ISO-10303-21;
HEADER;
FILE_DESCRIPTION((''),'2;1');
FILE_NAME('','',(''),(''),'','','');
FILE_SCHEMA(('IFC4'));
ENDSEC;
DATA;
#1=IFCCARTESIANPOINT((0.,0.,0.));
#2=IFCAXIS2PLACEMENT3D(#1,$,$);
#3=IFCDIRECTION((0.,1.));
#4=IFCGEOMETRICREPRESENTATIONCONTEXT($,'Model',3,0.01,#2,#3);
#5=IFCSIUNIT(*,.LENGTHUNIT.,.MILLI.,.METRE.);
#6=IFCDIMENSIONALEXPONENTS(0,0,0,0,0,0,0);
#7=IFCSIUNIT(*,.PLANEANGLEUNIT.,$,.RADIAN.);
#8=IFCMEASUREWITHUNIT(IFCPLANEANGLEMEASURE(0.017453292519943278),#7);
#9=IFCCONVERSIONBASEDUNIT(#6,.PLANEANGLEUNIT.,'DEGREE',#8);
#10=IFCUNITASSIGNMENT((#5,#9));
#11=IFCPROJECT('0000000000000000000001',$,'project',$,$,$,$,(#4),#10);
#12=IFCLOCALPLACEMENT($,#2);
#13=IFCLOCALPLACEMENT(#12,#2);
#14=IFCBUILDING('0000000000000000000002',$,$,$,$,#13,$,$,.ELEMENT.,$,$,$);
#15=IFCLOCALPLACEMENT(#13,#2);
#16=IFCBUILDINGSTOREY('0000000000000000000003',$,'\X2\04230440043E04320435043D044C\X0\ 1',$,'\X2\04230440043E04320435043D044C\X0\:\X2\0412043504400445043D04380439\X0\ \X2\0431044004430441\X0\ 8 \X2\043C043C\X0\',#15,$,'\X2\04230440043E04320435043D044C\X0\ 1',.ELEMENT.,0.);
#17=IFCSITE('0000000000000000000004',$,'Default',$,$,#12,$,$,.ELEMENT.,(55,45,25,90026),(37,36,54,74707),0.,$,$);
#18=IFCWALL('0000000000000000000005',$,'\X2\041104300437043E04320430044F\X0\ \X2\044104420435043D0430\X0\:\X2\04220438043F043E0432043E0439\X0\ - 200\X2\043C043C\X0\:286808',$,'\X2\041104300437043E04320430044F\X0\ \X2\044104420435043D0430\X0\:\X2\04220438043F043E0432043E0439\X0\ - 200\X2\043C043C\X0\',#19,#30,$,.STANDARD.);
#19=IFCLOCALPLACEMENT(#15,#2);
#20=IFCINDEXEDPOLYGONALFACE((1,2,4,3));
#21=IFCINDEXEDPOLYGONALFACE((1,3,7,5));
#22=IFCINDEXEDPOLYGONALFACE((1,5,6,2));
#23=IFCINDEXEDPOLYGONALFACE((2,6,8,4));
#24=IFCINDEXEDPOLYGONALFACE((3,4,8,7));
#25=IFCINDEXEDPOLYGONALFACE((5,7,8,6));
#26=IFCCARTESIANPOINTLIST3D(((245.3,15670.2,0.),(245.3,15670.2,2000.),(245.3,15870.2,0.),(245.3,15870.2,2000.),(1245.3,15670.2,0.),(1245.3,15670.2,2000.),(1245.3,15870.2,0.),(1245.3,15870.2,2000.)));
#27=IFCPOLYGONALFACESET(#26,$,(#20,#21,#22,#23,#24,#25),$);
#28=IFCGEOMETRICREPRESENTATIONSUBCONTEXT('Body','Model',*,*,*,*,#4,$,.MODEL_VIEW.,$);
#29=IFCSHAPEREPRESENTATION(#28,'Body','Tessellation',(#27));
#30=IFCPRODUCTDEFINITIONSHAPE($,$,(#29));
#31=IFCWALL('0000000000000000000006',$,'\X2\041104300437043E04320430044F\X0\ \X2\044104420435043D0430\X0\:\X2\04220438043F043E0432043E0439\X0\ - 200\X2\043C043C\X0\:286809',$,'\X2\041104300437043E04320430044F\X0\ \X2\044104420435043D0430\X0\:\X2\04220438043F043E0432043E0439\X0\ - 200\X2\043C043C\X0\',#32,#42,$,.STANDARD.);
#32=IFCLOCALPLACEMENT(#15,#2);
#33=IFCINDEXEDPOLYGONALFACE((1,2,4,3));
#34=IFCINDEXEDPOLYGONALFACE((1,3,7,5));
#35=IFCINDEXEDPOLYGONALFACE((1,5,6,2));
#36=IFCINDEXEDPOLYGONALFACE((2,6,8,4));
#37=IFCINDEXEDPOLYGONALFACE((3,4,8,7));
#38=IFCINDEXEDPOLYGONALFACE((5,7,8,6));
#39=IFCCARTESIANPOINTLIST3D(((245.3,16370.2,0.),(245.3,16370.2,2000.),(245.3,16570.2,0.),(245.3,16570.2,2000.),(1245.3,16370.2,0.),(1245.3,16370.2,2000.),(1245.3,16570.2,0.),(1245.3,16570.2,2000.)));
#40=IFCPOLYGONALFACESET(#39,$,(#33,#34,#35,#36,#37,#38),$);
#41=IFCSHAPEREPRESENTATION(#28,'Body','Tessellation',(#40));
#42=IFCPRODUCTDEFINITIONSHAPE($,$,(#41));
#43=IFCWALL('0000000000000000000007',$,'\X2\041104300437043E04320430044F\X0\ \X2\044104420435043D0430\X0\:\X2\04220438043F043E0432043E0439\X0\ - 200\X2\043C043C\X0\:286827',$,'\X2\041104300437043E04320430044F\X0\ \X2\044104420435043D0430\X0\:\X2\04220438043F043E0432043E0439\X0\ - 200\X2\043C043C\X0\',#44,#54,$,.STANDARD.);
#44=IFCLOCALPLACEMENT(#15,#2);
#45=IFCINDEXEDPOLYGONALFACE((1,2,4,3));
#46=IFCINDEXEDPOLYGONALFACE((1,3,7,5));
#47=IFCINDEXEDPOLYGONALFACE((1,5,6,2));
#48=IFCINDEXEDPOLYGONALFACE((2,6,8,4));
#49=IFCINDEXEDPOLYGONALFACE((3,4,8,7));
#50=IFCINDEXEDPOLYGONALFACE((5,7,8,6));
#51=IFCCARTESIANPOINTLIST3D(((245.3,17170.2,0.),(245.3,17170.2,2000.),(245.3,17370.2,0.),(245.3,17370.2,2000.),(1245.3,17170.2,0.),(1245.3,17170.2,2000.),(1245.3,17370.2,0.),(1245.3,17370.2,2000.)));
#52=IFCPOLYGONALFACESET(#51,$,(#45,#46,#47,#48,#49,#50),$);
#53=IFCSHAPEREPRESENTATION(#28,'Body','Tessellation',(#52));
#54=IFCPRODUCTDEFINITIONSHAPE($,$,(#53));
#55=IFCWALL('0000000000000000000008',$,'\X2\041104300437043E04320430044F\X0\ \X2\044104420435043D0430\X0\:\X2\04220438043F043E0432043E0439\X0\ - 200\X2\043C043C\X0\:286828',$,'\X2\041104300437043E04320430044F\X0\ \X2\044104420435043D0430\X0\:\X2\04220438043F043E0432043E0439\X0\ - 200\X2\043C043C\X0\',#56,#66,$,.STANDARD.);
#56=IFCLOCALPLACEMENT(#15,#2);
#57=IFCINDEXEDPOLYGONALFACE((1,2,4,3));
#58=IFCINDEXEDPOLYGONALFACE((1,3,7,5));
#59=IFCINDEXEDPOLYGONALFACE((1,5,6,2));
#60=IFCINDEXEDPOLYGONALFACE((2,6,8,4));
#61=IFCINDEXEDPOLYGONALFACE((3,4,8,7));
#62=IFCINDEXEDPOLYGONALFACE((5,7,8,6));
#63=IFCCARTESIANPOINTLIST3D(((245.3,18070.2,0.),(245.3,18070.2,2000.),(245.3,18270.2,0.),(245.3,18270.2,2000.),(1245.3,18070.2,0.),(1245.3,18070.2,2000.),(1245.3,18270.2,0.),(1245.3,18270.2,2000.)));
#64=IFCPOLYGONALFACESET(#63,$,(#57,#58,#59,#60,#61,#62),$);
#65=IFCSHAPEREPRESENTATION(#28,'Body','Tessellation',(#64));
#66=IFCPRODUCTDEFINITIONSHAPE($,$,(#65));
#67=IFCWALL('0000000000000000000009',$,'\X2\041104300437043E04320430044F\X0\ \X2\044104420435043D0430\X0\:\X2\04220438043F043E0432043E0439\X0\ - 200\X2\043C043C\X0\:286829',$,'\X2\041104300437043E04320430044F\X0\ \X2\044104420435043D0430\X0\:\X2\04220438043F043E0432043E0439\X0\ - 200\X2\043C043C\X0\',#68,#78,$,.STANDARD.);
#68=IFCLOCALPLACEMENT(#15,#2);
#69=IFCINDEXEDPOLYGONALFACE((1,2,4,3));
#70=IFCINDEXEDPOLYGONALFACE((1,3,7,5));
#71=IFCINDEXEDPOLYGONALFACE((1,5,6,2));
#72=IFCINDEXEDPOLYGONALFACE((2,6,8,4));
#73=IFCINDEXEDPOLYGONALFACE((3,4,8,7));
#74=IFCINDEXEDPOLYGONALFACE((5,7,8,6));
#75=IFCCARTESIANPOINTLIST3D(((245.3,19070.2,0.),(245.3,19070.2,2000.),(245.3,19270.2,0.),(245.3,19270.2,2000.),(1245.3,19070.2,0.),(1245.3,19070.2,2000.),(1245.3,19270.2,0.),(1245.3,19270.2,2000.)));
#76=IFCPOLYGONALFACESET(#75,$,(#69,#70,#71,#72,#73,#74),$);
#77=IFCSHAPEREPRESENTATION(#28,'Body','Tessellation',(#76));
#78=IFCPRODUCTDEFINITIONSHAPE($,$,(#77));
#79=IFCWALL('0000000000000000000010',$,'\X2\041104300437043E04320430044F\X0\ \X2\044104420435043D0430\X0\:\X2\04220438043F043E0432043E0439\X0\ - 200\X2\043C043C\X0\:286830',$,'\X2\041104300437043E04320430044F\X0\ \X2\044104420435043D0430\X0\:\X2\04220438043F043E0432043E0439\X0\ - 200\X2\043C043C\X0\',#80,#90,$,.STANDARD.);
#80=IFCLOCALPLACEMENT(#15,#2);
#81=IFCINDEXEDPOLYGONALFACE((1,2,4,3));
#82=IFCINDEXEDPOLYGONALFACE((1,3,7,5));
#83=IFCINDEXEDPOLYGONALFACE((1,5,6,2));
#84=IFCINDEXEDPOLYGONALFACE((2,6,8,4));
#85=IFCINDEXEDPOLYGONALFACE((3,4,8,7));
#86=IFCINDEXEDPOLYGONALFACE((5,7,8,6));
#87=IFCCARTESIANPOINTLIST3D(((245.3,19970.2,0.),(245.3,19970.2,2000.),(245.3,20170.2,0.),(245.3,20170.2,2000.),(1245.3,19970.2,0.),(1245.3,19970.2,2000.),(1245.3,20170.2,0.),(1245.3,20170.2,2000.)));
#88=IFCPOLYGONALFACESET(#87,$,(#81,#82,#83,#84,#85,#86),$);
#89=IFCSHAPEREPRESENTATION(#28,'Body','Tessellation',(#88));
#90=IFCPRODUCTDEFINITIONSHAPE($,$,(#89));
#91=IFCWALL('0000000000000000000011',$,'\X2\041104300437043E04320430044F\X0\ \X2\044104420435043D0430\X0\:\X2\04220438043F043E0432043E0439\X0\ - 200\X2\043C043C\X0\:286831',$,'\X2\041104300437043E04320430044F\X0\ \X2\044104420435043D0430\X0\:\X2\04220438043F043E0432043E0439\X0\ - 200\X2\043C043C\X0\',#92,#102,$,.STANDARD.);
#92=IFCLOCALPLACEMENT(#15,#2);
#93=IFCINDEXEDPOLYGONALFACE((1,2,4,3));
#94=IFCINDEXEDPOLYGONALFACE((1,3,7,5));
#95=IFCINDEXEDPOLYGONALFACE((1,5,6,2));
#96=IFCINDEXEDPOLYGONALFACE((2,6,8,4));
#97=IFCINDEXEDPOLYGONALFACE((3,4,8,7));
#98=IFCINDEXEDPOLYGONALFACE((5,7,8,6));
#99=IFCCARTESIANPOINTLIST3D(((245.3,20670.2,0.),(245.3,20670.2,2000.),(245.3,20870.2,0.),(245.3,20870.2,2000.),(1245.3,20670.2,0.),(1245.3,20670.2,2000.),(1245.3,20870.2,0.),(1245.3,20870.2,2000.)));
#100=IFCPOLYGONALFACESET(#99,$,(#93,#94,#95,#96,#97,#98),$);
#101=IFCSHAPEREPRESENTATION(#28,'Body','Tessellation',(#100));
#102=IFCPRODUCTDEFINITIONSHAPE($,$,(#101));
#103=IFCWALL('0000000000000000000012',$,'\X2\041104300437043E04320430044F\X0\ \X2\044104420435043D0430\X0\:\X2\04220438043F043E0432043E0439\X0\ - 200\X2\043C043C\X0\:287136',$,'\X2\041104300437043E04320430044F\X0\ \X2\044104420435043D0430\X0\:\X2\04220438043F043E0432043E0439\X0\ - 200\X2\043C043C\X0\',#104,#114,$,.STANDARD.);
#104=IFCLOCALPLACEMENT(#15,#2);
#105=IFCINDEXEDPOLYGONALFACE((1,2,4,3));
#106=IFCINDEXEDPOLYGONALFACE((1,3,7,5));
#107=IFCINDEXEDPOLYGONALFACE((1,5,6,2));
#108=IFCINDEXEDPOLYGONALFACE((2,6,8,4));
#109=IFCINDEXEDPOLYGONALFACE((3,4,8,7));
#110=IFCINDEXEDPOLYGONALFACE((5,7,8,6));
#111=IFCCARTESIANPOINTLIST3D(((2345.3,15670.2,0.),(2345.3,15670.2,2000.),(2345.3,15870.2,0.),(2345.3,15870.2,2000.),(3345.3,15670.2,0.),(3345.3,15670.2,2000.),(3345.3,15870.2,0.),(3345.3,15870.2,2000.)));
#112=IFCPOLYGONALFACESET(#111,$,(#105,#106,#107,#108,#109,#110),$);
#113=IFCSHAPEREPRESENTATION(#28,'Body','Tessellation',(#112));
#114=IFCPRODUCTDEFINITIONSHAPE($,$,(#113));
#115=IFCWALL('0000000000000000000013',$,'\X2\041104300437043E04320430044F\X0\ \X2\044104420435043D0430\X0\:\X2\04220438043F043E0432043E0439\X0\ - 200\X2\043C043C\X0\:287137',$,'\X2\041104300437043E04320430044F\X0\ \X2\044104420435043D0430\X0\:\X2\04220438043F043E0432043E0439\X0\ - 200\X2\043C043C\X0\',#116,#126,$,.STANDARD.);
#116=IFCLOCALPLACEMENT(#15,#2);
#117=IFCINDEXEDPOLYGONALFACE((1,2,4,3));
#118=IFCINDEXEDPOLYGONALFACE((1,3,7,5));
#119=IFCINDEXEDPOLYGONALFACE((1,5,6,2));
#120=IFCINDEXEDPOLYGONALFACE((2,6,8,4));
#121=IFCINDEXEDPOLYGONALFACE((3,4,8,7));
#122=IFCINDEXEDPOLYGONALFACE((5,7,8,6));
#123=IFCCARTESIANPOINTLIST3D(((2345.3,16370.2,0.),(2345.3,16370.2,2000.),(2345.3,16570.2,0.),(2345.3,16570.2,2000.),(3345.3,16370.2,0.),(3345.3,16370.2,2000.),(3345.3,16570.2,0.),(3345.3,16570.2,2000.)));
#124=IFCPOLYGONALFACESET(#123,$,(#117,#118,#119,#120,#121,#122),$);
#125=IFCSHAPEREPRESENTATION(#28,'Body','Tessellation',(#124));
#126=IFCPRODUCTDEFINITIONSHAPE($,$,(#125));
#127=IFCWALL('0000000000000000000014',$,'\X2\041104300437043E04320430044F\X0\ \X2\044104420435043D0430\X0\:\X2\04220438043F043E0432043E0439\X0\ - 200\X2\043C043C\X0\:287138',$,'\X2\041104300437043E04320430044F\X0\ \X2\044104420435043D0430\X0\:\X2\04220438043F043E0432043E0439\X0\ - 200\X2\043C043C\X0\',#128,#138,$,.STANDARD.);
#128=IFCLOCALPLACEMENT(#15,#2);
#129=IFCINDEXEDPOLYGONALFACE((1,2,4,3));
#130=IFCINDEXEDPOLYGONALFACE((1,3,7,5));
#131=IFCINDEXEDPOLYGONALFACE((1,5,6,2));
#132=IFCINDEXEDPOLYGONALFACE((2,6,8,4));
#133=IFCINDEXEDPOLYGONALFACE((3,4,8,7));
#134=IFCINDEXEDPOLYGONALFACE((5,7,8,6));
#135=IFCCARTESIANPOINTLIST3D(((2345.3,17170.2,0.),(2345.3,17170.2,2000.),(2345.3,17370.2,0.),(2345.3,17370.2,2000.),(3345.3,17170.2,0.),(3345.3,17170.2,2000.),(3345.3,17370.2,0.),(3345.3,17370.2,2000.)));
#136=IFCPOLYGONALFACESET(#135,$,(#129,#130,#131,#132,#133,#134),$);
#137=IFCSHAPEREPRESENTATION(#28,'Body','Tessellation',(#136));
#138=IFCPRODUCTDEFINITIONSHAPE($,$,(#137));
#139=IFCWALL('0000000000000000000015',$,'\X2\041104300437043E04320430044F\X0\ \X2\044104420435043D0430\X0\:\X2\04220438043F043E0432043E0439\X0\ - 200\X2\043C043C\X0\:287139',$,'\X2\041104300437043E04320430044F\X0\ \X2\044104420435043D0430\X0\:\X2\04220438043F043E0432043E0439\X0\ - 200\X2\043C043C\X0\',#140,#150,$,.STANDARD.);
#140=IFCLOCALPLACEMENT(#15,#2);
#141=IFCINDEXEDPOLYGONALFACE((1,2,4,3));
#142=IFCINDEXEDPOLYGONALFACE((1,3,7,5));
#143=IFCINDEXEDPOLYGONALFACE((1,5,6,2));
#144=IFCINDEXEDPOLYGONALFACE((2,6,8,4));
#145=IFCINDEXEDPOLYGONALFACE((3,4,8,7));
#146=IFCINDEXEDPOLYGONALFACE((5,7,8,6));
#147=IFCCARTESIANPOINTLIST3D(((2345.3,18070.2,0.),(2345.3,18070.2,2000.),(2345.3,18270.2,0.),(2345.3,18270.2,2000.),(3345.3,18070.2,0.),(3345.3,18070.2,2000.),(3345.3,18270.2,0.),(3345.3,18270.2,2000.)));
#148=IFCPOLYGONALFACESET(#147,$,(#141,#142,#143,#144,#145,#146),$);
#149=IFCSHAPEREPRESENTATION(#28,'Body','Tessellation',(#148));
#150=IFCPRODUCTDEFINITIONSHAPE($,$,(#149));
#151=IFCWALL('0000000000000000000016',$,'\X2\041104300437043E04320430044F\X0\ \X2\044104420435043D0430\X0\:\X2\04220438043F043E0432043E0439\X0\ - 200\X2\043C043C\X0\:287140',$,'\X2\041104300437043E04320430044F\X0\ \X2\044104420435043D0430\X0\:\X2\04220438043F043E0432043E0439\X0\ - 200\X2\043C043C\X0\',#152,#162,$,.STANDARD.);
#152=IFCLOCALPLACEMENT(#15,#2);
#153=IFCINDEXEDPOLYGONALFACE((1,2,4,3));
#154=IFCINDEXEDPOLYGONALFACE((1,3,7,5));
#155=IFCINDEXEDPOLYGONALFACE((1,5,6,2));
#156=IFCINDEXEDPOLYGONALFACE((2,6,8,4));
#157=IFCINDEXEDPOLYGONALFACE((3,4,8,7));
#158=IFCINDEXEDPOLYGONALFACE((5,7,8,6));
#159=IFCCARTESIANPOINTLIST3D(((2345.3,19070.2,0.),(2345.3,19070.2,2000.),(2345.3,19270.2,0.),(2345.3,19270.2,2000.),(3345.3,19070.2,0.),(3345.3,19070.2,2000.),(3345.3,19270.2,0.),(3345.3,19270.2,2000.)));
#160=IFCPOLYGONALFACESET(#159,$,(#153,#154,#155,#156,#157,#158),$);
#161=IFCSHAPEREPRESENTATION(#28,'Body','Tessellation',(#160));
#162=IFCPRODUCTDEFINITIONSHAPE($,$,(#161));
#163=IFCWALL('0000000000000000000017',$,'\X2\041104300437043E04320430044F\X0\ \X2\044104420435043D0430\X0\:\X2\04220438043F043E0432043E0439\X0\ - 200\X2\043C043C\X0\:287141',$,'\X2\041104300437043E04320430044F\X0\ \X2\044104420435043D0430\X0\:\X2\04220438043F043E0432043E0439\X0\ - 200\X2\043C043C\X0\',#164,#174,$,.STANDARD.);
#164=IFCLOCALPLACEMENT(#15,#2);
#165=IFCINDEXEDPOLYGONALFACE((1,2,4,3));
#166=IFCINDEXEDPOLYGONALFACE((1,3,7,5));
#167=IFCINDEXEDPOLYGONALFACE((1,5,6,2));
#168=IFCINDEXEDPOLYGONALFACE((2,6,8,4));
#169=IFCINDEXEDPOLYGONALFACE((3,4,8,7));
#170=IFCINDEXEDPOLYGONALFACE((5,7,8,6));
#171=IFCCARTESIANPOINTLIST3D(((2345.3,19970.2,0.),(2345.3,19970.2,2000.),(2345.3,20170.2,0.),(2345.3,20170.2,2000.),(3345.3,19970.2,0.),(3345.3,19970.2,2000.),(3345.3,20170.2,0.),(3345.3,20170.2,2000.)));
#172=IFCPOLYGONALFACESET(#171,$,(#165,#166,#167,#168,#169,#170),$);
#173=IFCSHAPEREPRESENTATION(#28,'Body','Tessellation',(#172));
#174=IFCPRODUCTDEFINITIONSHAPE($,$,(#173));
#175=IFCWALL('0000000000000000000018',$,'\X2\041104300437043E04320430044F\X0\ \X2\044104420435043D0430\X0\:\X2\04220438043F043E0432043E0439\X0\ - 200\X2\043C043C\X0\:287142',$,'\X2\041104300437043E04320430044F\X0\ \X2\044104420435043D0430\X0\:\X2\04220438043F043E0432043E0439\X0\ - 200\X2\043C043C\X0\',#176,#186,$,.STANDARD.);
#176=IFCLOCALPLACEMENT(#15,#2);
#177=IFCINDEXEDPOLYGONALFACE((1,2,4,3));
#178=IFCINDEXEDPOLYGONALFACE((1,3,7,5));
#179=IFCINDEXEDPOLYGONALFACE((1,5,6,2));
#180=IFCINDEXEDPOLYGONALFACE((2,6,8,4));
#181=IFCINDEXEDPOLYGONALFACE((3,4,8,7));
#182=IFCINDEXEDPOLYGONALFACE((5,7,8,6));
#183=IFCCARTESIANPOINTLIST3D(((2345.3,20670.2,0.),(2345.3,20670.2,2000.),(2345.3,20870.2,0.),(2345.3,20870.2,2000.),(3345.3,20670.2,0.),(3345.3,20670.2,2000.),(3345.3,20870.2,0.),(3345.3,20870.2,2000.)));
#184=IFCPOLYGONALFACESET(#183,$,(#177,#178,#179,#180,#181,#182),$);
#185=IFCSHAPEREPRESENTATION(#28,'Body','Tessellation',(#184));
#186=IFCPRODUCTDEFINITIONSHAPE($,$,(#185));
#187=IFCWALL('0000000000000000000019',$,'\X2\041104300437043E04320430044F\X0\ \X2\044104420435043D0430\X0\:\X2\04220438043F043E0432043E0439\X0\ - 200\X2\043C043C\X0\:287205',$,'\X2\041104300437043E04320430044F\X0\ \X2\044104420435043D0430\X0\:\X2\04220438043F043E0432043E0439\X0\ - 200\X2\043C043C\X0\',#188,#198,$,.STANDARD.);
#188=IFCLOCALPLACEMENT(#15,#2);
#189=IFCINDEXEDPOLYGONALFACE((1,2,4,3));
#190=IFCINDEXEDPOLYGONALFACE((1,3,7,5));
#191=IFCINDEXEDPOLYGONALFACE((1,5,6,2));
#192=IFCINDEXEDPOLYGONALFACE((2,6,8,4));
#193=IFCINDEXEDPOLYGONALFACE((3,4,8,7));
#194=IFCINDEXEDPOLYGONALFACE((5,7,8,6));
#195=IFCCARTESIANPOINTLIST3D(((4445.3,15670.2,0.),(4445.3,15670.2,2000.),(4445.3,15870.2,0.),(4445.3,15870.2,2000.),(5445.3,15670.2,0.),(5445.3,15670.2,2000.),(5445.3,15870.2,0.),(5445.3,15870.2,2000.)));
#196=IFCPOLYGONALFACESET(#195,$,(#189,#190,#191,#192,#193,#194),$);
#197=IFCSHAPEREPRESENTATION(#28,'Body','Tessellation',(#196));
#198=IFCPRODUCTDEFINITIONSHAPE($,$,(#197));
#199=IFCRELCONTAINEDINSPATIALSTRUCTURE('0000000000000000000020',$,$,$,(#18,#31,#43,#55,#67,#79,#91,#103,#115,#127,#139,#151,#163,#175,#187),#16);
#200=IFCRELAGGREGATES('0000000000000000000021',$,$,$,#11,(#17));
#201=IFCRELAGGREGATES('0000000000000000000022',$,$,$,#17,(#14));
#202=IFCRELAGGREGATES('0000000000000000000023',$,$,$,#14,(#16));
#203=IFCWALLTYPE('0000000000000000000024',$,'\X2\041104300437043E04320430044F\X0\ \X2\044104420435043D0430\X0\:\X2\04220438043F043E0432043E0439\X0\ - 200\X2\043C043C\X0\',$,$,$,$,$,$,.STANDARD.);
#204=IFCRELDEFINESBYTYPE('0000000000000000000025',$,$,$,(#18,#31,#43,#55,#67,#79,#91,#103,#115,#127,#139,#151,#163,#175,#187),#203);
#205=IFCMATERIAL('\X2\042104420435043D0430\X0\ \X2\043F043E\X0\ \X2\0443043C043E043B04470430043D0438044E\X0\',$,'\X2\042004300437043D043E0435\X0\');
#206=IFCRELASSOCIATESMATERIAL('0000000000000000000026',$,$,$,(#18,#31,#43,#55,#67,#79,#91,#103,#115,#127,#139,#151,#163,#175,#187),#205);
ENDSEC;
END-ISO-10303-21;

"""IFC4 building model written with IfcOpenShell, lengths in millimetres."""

from ifc_helpers import new_model, entity, si_unit, converted_unit, direction, frame, origin, place, context, subcontext, project, spatial, indexed_curve, outline, extrude, material, type_object, element, save


model = new_model("IFC4")

# Units and contexts
model_context = context("Model", 3, precision=0.01, world=origin(), true_north=direction((0.0, 1.0)))
body_context = subcontext(model_context, "Body", "Model", "MODEL_VIEW")
ifc_project = project(units=[si_unit("LENGTHUNIT", "METRE", prefix="MILLI"), converted_unit("PLANEANGLEUNIT", "DEGREE", entity("IfcPlaneAngleMeasure", 0.017453292519943278), si_unit("PLANEANGLEUNIT", "RADIAN"), dimensions=[0, 0, 0, 0, 0, 0, 0])], contexts=[model_context])

# Site, building, storey
site_placement = place(None, origin())
site = spatial("IfcSite", under=ifc_project, at=site_placement, Name="Default", CompositionType="ELEMENT", RefLatitude=(55, 45, 25, 90026), RefLongitude=(37, 36, 54, 74707), RefElevation=0.0)
building_placement = place(site_placement, origin())
building = spatial("IfcBuilding", under=site, at=building_placement, CompositionType="ELEMENT")
storey_placement = place(building_placement, origin())
storey = spatial("IfcBuildingStorey", under=building, at=storey_placement, Name="Уровень 1", ObjectType="Уровень:Верхний брус 8 мм", LongName="Уровень 1", CompositionType="ELEMENT", Elevation=0.0)

# Walls
ifc_material = material(Name="Стена по умолчанию", Category="Разное")
wall_type = type_object("IfcWallType", Name="Базовая стена:Типовой - 200мм", PredefinedType="STANDARD")
wall_1_placement = place(storey_placement, frame((245.3, 15770.2, 0.0)))
element("IfcWall", 1, at=wall_1_placement, inside=storey, type_object=wall_type, material=ifc_material, Name="Базовая стена:Типовой - 200мм:286808", ObjectType="Базовая стена:Типовой - 200мм", PredefinedType="STANDARD", context=body_context, shape_type="SweptSolid", body=[
    extrude(outline(indexed_curve([(1000.0, 100.0), (0.0, 100.0), (0.0, -100.0), (1000.0, -100.0), (1000.0, 100.0)], self_intersect=False)), origin(), (0.0, 0.0, 1.0), 2000.0),
])
wall_2_placement = place(storey_placement, frame((245.3, 16470.2, 0.0)))
element("IfcWall", 2, at=wall_2_placement, inside=storey, type_object=wall_type, material=ifc_material, Name="Базовая стена:Типовой - 200мм:286809", ObjectType="Базовая стена:Типовой - 200мм", PredefinedType="STANDARD", context=body_context, shape_type="SweptSolid", body=[
    extrude(outline(indexed_curve([(1000.0, 100.0), (0.0, 100.0), (0.0, -100.0), (1000.0, -100.0), (1000.0, 100.0)], self_intersect=False)), origin(), (0.0, 0.0, 1.0), 2000.0),
])
wall_3_placement = place(storey_placement, frame((245.3, 17270.2, 0.0)))
element("IfcWall", 3, at=wall_3_placement, inside=storey, type_object=wall_type, material=ifc_material, Name="Базовая стена:Типовой - 200мм:286827", ObjectType="Базовая стена:Типовой - 200мм", PredefinedType="STANDARD", context=body_context, shape_type="SweptSolid", body=[
    extrude(outline(indexed_curve([(1000.0, 100.0), (0.0, 100.0), (0.0, -100.0), (1000.0, -100.0), (1000.0, 100.0)], self_intersect=False)), origin(), (0.0, 0.0, 1.0), 2000.0),
])
for number, where, name in (
    (4, (245.3, 18170.2, 0.0), "Базовая стена:Типовой - 200мм:286828"),
    (5, (245.3, 19170.2, 0.0), "Базовая стена:Типовой - 200мм:286829"),
):
    element("IfcWall", number, at=place(storey_placement, frame(where)), inside=storey, type_object=wall_type, material=ifc_material, Name=name, ObjectType="Базовая стена:Типовой - 200мм", PredefinedType="STANDARD", context=body_context, shape_type="SweptSolid", body=[
        extrude(outline(indexed_curve([(1000.0, 100.0), (0.0, 100.0), (0.0, -100.0), (1000.0, -100.0), (1000.0, 100.0)], self_intersect=False)), origin(), (0.0, 0.0, 1.0), 2000.0),
    ])
wall_4_placement = place(storey_placement, frame((245.3, 20070.2, 0.0)))
element("IfcWall", 6, at=wall_4_placement, inside=storey, type_object=wall_type, material=ifc_material, Name="Базовая стена:Типовой - 200мм:286830", ObjectType="Базовая стена:Типовой - 200мм", PredefinedType="STANDARD", context=body_context, shape_type="SweptSolid", body=[
    extrude(outline(indexed_curve([(1000.0, 100.0), (0.0, 100.0), (0.0, -100.0), (1000.0, -100.0), (1000.0, 100.0)], self_intersect=False)), origin(), (0.0, 0.0, 1.0), 2000.0),
])
wall_5_placement = place(storey_placement, frame((245.3, 20770.2, 0.0)))
element("IfcWall", 7, at=wall_5_placement, inside=storey, type_object=wall_type, material=ifc_material, Name="Базовая стена:Типовой - 200мм:286831", ObjectType="Базовая стена:Типовой - 200мм", PredefinedType="STANDARD", context=body_context, shape_type="SweptSolid", body=[
    extrude(outline(indexed_curve([(1000.0, 100.0), (0.0, 100.0), (0.0, -100.0), (1000.0, -100.0), (1000.0, 100.0)], self_intersect=False)), origin(), (0.0, 0.0, 1.0), 2000.0),
])
wall_6_placement = place(storey_placement, frame((2345.3, 15770.2, 0.0)))
element("IfcWall", 8, at=wall_6_placement, inside=storey, type_object=wall_type, material=ifc_material, Name="Базовая стена:Типовой - 200мм:287136", ObjectType="Базовая стена:Типовой - 200мм", PredefinedType="STANDARD", context=body_context, shape_type="SweptSolid", body=[
    extrude(outline(indexed_curve([(1000.0, 100.0), (0.0, 100.0), (0.0, -100.0), (1000.0, -100.0), (1000.0, 100.0)], self_intersect=False)), origin(), (0.0, 0.0, 1.0), 2000.0),
])
wall_7_placement = place(storey_placement, frame((2345.3, 16470.2, 0.0)))
element("IfcWall", 9, at=wall_7_placement, inside=storey, type_object=wall_type, material=ifc_material, Name="Базовая стена:Типовой - 200мм:287137", ObjectType="Базовая стена:Типовой - 200мм", PredefinedType="STANDARD", context=body_context, shape_type="SweptSolid", body=[
    extrude(outline(indexed_curve([(1000.0, 100.0), (0.0, 100.0), (0.0, -100.0), (1000.0, -100.0), (1000.0, 100.0)], self_intersect=False)), origin(), (0.0, 0.0, 1.0), 2000.0),
])
wall_8_placement = place(storey_placement, frame((2345.3, 17270.2, 0.0)))
element("IfcWall", 10, at=wall_8_placement, inside=storey, type_object=wall_type, material=ifc_material, Name="Базовая стена:Типовой - 200мм:287138", ObjectType="Базовая стена:Типовой - 200мм", PredefinedType="STANDARD", context=body_context, shape_type="SweptSolid", body=[
    extrude(outline(indexed_curve([(1000.0, 100.0), (0.0, 100.0), (0.0, -100.0), (1000.0, -100.0), (1000.0, 100.0)], self_intersect=False)), origin(), (0.0, 0.0, 1.0), 2000.0),
])
for number, where, name in (
    (11, (2345.3, 18170.2, 0.0), "Базовая стена:Типовой - 200мм:287139"),
    (12, (2345.3, 19170.2, 0.0), "Базовая стена:Типовой - 200мм:287140"),
):
    element("IfcWall", number, at=place(storey_placement, frame(where)), inside=storey, type_object=wall_type, material=ifc_material, Name=name, ObjectType="Базовая стена:Типовой - 200мм", PredefinedType="STANDARD", context=body_context, shape_type="SweptSolid", body=[
        extrude(outline(indexed_curve([(1000.0, 100.0), (0.0, 100.0), (0.0, -100.0), (1000.0, -100.0), (1000.0, 100.0)], self_intersect=False)), origin(), (0.0, 0.0, 1.0), 2000.0),
    ])
for number, where, name in (
    (13, (2345.3, 20070.2, 0.0), "Базовая стена:Типовой - 200мм:287141"),
    (14, (2345.3, 20770.2, 0.0), "Базовая стена:Типовой - 200мм:287142"),
):
    element("IfcWall", number, at=place(storey_placement, frame(where)), inside=storey, type_object=wall_type, material=ifc_material, Name=name, ObjectType="Базовая стена:Типовой - 200мм", PredefinedType="STANDARD", context=body_context, shape_type="SweptSolid", body=[
        extrude(outline(indexed_curve([(1000.0, 100.0), (0.0, 100.0), (0.0, -100.0), (1000.0, -100.0), (1000.0, 100.0)], self_intersect=False)), origin(), (0.0, 0.0, 1.0), 2000.0),
    ])
wall_9_placement = place(storey_placement, frame((4445.3, 15770.2, 0.0)))
element("IfcWall", 15, at=wall_9_placement, inside=storey, type_object=wall_type, material=ifc_material, Name="Базовая стена:Типовой - 200мм:287205", ObjectType="Базовая стена:Типовой - 200мм", PredefinedType="STANDARD", context=body_context, shape_type="SweptSolid", body=[
    extrude(outline(indexed_curve([(1000.0, 100.0), (0.0, 100.0), (0.0, -100.0), (1000.0, -100.0), (1000.0, 100.0)], self_intersect=False)), origin(), (0.0, 0.0, 1.0), 2000.0),
])

save(model, "model.ifc")
